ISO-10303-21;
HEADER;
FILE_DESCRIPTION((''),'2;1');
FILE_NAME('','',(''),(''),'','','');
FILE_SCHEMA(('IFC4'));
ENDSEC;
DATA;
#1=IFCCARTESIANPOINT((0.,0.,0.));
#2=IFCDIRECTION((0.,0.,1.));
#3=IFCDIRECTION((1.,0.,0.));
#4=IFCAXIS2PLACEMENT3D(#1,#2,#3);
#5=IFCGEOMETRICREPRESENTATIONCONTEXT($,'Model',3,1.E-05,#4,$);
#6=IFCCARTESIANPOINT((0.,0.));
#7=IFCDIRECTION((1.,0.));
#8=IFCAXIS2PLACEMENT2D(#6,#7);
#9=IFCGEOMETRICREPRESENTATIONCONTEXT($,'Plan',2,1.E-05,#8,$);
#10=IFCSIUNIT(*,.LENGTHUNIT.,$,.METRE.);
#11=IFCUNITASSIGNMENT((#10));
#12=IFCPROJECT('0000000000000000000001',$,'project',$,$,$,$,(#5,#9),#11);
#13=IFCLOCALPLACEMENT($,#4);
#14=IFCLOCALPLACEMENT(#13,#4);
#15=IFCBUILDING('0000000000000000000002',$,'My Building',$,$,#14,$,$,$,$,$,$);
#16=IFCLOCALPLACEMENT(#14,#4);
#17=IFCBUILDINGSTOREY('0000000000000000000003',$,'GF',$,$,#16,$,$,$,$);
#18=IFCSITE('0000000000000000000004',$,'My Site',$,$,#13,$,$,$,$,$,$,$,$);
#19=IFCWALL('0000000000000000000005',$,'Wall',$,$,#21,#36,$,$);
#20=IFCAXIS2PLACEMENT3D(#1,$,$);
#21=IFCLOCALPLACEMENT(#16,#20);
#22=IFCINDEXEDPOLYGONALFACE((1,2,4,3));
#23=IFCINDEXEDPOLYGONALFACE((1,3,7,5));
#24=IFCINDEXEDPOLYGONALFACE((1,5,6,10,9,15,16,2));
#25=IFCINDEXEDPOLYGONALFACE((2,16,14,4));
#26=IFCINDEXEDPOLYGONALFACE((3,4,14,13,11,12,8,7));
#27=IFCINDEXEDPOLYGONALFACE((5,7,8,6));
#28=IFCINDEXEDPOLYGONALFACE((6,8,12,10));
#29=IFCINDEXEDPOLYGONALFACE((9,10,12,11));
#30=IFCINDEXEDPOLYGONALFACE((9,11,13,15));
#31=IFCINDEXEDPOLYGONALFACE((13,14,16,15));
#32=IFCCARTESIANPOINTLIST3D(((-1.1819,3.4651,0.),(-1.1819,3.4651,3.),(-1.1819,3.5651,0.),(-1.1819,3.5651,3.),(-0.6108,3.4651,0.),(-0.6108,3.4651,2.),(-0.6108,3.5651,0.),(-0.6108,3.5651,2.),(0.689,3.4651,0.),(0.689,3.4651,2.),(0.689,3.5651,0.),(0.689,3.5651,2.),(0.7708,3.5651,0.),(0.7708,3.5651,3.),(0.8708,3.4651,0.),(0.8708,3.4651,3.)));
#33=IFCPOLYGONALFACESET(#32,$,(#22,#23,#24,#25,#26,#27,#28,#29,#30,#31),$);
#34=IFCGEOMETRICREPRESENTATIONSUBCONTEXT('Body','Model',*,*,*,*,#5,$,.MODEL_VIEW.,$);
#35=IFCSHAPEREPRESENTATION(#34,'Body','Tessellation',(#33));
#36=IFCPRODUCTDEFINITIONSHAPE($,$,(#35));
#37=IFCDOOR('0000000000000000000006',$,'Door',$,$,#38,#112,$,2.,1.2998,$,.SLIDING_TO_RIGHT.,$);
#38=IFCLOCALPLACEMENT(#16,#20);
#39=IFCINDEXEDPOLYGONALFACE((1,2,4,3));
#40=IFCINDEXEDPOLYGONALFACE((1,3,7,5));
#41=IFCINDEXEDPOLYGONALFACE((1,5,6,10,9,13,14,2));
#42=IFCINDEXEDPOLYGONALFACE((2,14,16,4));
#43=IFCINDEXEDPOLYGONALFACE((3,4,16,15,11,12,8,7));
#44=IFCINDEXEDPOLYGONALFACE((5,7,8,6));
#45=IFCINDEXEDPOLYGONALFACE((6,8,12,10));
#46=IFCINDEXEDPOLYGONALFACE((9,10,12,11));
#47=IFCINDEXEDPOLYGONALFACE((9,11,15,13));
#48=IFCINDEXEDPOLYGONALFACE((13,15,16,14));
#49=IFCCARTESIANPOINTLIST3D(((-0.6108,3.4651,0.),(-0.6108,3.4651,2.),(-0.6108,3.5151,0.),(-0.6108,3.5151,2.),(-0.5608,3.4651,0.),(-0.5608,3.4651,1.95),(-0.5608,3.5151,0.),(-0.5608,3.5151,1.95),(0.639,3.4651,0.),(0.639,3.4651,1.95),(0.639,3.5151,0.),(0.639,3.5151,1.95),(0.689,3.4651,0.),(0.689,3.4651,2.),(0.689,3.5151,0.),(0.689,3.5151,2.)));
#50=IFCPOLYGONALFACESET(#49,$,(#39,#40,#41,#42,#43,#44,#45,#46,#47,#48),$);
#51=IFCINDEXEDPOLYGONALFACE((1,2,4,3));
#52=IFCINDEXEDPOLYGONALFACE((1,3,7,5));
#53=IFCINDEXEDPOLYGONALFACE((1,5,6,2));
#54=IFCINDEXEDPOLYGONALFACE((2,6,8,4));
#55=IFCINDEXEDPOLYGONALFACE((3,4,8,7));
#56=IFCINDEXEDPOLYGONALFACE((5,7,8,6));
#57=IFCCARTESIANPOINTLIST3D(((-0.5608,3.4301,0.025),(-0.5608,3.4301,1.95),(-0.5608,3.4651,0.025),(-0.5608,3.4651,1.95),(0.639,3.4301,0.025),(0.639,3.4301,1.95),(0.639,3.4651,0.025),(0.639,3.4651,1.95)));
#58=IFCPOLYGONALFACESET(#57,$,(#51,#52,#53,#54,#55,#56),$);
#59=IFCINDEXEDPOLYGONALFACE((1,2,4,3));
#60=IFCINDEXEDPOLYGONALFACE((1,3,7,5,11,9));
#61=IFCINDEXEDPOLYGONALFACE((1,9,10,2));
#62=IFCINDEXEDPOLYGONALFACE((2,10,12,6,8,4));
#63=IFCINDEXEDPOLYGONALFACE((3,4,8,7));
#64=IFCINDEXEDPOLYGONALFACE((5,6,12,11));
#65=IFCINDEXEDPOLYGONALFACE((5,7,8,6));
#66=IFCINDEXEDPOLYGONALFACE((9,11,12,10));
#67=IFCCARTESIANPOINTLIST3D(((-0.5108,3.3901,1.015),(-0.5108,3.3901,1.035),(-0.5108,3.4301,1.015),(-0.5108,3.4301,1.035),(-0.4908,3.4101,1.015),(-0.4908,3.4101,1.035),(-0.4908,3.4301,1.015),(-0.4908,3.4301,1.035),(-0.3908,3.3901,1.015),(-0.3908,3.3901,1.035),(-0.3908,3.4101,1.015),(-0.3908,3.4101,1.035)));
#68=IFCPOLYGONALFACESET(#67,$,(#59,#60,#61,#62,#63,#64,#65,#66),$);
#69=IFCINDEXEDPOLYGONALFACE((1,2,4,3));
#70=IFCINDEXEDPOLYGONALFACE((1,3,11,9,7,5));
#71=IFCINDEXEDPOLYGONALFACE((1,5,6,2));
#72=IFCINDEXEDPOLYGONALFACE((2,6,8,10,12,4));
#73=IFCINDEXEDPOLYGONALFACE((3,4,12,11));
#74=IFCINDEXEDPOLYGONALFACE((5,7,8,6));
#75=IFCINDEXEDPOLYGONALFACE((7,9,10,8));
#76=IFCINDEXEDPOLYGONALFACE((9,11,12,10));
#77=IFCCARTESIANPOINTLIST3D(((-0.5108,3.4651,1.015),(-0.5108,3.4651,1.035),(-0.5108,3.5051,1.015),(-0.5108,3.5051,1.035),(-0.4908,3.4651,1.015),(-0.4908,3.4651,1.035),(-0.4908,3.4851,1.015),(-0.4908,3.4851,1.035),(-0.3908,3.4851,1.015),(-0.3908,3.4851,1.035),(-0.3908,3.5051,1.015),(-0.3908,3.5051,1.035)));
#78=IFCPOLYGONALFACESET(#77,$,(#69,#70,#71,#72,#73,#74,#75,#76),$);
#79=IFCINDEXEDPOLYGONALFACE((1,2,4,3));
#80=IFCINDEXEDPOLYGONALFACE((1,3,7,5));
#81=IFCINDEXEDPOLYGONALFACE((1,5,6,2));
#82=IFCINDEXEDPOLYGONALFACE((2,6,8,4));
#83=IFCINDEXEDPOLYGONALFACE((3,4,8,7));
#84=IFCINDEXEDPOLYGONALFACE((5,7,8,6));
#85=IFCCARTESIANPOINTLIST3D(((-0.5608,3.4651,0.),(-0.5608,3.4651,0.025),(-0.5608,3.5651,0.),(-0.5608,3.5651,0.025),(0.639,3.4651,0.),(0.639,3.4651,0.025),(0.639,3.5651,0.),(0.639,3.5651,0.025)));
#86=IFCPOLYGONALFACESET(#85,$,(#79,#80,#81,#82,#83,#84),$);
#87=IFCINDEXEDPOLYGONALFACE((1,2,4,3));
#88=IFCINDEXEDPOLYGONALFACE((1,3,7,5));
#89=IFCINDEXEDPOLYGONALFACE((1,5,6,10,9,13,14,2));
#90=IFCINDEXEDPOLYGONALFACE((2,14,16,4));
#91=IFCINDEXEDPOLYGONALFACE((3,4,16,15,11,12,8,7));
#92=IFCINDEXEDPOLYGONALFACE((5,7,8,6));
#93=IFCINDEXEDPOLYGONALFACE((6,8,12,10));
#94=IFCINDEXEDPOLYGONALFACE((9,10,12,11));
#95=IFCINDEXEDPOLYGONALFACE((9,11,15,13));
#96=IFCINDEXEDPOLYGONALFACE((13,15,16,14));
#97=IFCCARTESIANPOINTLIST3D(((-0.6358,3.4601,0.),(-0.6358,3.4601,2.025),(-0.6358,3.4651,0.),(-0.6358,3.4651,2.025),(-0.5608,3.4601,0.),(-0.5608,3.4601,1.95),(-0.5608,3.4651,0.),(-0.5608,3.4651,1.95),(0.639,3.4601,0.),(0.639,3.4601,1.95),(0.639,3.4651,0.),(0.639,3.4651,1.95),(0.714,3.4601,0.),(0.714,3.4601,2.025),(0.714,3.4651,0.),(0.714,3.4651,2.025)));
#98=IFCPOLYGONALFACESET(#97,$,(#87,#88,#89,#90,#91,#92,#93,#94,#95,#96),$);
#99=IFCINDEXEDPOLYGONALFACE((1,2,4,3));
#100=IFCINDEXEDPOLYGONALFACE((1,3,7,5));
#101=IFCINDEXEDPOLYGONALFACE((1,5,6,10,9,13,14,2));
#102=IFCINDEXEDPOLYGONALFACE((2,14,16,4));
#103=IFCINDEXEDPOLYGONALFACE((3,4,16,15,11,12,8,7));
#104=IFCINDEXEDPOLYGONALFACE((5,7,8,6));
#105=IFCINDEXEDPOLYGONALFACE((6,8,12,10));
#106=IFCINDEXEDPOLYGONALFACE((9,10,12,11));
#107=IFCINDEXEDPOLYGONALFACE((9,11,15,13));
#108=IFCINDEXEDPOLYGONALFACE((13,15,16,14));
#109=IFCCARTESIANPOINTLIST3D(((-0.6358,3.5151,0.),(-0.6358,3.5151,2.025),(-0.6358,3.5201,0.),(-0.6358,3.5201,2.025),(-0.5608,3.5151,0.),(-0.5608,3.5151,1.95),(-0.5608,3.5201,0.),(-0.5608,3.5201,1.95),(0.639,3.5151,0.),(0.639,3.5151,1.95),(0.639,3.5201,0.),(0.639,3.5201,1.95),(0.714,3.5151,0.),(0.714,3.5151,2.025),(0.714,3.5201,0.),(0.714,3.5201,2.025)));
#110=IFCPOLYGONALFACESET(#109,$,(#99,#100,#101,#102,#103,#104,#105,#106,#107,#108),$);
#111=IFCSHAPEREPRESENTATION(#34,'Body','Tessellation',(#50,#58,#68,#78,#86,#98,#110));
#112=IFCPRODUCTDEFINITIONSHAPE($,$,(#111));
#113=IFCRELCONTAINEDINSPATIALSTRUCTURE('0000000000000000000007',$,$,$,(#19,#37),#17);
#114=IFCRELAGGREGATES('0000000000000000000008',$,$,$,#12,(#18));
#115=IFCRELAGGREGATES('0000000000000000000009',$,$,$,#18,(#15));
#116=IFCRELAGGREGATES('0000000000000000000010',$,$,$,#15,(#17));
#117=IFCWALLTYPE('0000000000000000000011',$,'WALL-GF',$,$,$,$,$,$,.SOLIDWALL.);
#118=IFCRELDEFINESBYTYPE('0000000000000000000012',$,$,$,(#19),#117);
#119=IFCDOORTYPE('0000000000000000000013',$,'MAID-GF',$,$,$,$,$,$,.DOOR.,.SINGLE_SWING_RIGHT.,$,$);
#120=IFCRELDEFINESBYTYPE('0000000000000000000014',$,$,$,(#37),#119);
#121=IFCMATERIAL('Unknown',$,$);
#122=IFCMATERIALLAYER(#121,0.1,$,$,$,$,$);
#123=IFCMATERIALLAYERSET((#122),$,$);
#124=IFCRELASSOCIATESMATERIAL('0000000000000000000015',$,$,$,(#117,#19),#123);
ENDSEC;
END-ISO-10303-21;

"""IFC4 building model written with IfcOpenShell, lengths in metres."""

from ifc_helpers import new_model, entity, si_unit, frame, origin_with_axes, origin_2d_with_axis, place, context, subcontext, project, spatial, line, indexed_curve, outline, extrude, shape, source, transform, mapped, material, layer, layer_set, layer_usage, type_object, type_shapes, element, fill, save


model = new_model("IFC4")

# Units and contexts
model_context = context("Model", 3, precision=1e-05, world=origin_with_axes())
plan_context = context("Plan", 2, precision=1e-05, world=origin_2d_with_axis())
body_context_1 = subcontext(model_context, "Body", "Model", "MODEL_VIEW")
body_context_2 = subcontext(plan_context, "Body", "Plan", "PLAN_VIEW")
ifc_project = project(units=[si_unit("LENGTHUNIT", "METRE")], contexts=[model_context, plan_context])

# Site, building, storey
site_placement = place(None, origin_with_axes())
site = spatial("IfcSite", under=ifc_project, at=site_placement, Name="My Site")
building_placement = place(site_placement, origin_with_axes())
building = spatial("IfcBuilding", under=site, at=building_placement, Name="My Building")
storey_placement = place(building_placement, origin_with_axes())
storey = spatial("IfcBuildingStorey", under=building, at=storey_placement, Name="GF")

# Shared definitions
ifc_material = material(Name="Unknown")

# Shared definitions
ifc_layer_1 = layer(ifc_material, 0.1)
ifc_layer_set_1 = layer_set([ifc_layer_1])
wall_type = type_object("IfcWallType", Name="WALL-GF", PredefinedType="SOLIDWALL", material=ifc_layer_set_1)

# Wall, opening, door
ifc_layer_usage_1 = layer_usage(ifc_layer_set_1, "AXIS2", "POSITIVE", 0.0)
wall_1_placement = place(storey_placement, frame((0.7708, 3.5651, 0.0), z_axis=(0.0, 0.0, 1.0), x_axis=(-1.0, 0.0, 0.0)))
wall_1 = element("IfcWall", 1, at=wall_1_placement, inside=storey, type_object=wall_type, material=ifc_layer_usage_1, Name="Wall", context=body_context_1, shape_type="SweptSolid", body=[
    extrude(outline(indexed_curve([(0.0, 0.0), (-0.1, 0.1), (1.9528, 0.1), (1.9528, 0.0)], segments=[line(1, 2, 3, 4, 1)])), origin_with_axes(), (0.0, 0.0, 1.0), 3.0),
])
shared_shape_1 = source(origin_with_axes(), body_context_1, "Body", "SweptSolid", [
    extrude(outline(indexed_curve([(0.0, 0.0), (1.2998, 0.0), (1.2998, 2.0), (0.0, 2.0)], segments=[line(1, 2, 3, 4, 1)])), frame((0.0, -0.6, 0.0), z_axis=(0.0, -1.0, 0.0), x_axis=(1.0, 0.0, 0.0)), (0.0, 0.0, -1.0), 1.2),
])
opening_1_placement = place(wall_1_placement, frame((1.3816, 0.1, 0.0), z_axis=(0.0, 0.0, 1.0), x_axis=(-1.0, 0.0, 0.0)))
opening_1 = element("IfcOpeningElement", 2, at=opening_1_placement, cuts=wall_1, PredefinedType="OPENING", context=body_context_1, shape_type="MappedRepresentation", body=[
    mapped(shared_shape_1, transform((0.0, 0.0, 0.0), x_axis=(1.0, 0.0, 0.0), y_axis=(0.0, 1.0, 0.0), z_axis=(0.0, 0.0, 1.0), scale=1.0)),
])
door_type_1 = type_object("IfcDoorType", Name="MAID-GF", OperationType="SINGLE_SWING_RIGHT", PredefinedType="DOOR")
shared_shape_2 = source(origin_with_axes(), body_context_1, "Body", "SweptSolid", [
    extrude(outline(indexed_curve([(0.0, 0.0), (0.0, 2.0), (1.2998, 2.0), (1.2998, 0.0), (1.2498, 0.0), (1.2498, 1.95), (0.05, 1.95), (0.05, 0.0)], segments=[line(1, 2, 3, 4, 5, 6, 7, 8, 1)])), frame((0.0, 0.0, 0.0), z_axis=(0.0, -1.0, 0.0), x_axis=(1.0, 0.0, 0.0)), (0.0, 0.0, -1.0), 0.05),
    extrude(outline(indexed_curve([(0.0, 0.0), (1.1998, 0.0), (1.1998, 0.035), (0.0, 0.035)], segments=[line(1, 2, 3, 4, 1)])), frame((0.05, -0.035, 0.025), z_axis=(0.0, 0.0, 1.0), x_axis=(1.0, 0.0, 0.0)), (0.0, 0.0, 1.0), 1.925),
    extrude(outline(indexed_curve([(0.0, 0.0), (0.0, -0.04), (0.12, -0.04), (0.12, -0.02), (0.02, -0.02), (0.02, 0.0)], segments=[line(1, 2, 3, 4, 5, 6, 1)])), frame((0.1, -0.035, 1.015), z_axis=(0.0, 0.0, 1.0), x_axis=(1.0, 0.0, 0.0)), (0.0, 0.0, 1.0), 0.02),
    extrude(outline(indexed_curve([(0.0, 0.0), (0.0, 0.04), (0.12, 0.04), (0.12, 0.02), (0.02, 0.02), (0.02, 0.0)], segments=[line(1, 2, 3, 4, 5, 6, 1)])), frame((0.1, 0.0, 1.015), z_axis=(0.0, 0.0, 1.0), x_axis=(1.0, 0.0, 0.0)), (0.0, 0.0, 1.0), 0.02),
    extrude(outline(indexed_curve([(0.0, 0.0), (1.1998, 0.0), (1.1998, 0.1), (0.0, 0.1)], segments=[line(1, 2, 3, 4, 1)])), frame((0.05, 0.0, 0.0), z_axis=(0.0, 0.0, 1.0), x_axis=(1.0, 0.0, 0.0)), (0.0, 0.0, 1.0), 0.025),
    extrude(outline(indexed_curve([(0.0, 0.0), (0.0, 2.025), (1.3498, 2.025), (1.3498, 0.0), (1.2748, 0.0), (1.2748, 1.95), (0.075, 1.95), (0.075, 0.0)], segments=[line(1, 2, 3, 4, 5, 6, 7, 8, 1)])), frame((-0.025, -0.005, 0.0), z_axis=(0.0, -1.0, 0.0), x_axis=(1.0, 0.0, 0.0)), (0.0, 0.0, -1.0), 0.005),
    extrude(outline(indexed_curve([(0.0, 0.0), (0.0, 2.025), (1.3498, 2.025), (1.3498, 0.0), (1.2748, 0.0), (1.2748, 1.95), (0.075, 1.95), (0.075, 0.0)], segments=[line(1, 2, 3, 4, 5, 6, 7, 8, 1)])), frame((-0.025, 0.05, 0.0), z_axis=(0.0, -1.0, 0.0), x_axis=(1.0, 0.0, 0.0)), (0.0, 0.0, -1.0), 0.005),
])
shared_shape_3 = source(origin_with_axes(), body_context_2, "Body", "Curve2D", [
    entity("IfcIndexedPolyCurve", entity("IfcCartesianPointList2D", [[0.0, 0.0], [0.05, 0.0], [0.05, 0.05], [0.0, 0.05]]), [entity("IfcLineIndex", [1, 2, 3, 4, 1])]),
    entity("IfcIndexedPolyCurve", entity("IfcCartesianPointList2D", [[1.2998, 0.0], [1.2498, 0.0], [1.2498, 0.05], [1.2998, 0.05]]), [entity("IfcLineIndex", [1, 2, 3, 4, 1])]),
    entity("IfcIndexedPolyCurve", entity("IfcCartesianPointList2D", [[1.8497, -0.035], [0.6499, -0.035], [0.6499, 0.0], [1.8497, 0.0]]), [entity("IfcLineIndex", [1, 2, 3, 4, 1])]),
])
type_shapes(door_type_1, [shared_shape_2, shared_shape_3])
door_1_placement = place(opening_1_placement, frame((0.0, 0.0, 0.0), z_axis=(0.0, 0.0, 1.0), x_axis=(1.0, 0.0, 0.0)))
door_1 = element("IfcDoor", 3, at=door_1_placement, inside=storey, type_object=door_type_1, Name="Door", OperationType="SLIDING_TO_RIGHT", OverallHeight=2.0, OverallWidth=1.2998, shapes=[
    shape(body_context_1, "Body", "MappedRepresentation", [mapped(shared_shape_2, transform((0.0, 0.0, 0.0), x_axis=(1.0, 0.0, 0.0), y_axis=(0.0, 1.0, 0.0), z_axis=(0.0, 0.0, 1.0), scale=1.0))]),
    shape(body_context_2, "Body", "MappedRepresentation", [mapped(shared_shape_3, transform((0.0, 0.0, 0.0), x_axis=(1.0, 0.0, 0.0), y_axis=(0.0, 1.0, 0.0), z_axis=(0.0, 0.0, 1.0), scale=1.0))]),
])
fill(opening_1, door_1)

save(model, "model.ifc")
